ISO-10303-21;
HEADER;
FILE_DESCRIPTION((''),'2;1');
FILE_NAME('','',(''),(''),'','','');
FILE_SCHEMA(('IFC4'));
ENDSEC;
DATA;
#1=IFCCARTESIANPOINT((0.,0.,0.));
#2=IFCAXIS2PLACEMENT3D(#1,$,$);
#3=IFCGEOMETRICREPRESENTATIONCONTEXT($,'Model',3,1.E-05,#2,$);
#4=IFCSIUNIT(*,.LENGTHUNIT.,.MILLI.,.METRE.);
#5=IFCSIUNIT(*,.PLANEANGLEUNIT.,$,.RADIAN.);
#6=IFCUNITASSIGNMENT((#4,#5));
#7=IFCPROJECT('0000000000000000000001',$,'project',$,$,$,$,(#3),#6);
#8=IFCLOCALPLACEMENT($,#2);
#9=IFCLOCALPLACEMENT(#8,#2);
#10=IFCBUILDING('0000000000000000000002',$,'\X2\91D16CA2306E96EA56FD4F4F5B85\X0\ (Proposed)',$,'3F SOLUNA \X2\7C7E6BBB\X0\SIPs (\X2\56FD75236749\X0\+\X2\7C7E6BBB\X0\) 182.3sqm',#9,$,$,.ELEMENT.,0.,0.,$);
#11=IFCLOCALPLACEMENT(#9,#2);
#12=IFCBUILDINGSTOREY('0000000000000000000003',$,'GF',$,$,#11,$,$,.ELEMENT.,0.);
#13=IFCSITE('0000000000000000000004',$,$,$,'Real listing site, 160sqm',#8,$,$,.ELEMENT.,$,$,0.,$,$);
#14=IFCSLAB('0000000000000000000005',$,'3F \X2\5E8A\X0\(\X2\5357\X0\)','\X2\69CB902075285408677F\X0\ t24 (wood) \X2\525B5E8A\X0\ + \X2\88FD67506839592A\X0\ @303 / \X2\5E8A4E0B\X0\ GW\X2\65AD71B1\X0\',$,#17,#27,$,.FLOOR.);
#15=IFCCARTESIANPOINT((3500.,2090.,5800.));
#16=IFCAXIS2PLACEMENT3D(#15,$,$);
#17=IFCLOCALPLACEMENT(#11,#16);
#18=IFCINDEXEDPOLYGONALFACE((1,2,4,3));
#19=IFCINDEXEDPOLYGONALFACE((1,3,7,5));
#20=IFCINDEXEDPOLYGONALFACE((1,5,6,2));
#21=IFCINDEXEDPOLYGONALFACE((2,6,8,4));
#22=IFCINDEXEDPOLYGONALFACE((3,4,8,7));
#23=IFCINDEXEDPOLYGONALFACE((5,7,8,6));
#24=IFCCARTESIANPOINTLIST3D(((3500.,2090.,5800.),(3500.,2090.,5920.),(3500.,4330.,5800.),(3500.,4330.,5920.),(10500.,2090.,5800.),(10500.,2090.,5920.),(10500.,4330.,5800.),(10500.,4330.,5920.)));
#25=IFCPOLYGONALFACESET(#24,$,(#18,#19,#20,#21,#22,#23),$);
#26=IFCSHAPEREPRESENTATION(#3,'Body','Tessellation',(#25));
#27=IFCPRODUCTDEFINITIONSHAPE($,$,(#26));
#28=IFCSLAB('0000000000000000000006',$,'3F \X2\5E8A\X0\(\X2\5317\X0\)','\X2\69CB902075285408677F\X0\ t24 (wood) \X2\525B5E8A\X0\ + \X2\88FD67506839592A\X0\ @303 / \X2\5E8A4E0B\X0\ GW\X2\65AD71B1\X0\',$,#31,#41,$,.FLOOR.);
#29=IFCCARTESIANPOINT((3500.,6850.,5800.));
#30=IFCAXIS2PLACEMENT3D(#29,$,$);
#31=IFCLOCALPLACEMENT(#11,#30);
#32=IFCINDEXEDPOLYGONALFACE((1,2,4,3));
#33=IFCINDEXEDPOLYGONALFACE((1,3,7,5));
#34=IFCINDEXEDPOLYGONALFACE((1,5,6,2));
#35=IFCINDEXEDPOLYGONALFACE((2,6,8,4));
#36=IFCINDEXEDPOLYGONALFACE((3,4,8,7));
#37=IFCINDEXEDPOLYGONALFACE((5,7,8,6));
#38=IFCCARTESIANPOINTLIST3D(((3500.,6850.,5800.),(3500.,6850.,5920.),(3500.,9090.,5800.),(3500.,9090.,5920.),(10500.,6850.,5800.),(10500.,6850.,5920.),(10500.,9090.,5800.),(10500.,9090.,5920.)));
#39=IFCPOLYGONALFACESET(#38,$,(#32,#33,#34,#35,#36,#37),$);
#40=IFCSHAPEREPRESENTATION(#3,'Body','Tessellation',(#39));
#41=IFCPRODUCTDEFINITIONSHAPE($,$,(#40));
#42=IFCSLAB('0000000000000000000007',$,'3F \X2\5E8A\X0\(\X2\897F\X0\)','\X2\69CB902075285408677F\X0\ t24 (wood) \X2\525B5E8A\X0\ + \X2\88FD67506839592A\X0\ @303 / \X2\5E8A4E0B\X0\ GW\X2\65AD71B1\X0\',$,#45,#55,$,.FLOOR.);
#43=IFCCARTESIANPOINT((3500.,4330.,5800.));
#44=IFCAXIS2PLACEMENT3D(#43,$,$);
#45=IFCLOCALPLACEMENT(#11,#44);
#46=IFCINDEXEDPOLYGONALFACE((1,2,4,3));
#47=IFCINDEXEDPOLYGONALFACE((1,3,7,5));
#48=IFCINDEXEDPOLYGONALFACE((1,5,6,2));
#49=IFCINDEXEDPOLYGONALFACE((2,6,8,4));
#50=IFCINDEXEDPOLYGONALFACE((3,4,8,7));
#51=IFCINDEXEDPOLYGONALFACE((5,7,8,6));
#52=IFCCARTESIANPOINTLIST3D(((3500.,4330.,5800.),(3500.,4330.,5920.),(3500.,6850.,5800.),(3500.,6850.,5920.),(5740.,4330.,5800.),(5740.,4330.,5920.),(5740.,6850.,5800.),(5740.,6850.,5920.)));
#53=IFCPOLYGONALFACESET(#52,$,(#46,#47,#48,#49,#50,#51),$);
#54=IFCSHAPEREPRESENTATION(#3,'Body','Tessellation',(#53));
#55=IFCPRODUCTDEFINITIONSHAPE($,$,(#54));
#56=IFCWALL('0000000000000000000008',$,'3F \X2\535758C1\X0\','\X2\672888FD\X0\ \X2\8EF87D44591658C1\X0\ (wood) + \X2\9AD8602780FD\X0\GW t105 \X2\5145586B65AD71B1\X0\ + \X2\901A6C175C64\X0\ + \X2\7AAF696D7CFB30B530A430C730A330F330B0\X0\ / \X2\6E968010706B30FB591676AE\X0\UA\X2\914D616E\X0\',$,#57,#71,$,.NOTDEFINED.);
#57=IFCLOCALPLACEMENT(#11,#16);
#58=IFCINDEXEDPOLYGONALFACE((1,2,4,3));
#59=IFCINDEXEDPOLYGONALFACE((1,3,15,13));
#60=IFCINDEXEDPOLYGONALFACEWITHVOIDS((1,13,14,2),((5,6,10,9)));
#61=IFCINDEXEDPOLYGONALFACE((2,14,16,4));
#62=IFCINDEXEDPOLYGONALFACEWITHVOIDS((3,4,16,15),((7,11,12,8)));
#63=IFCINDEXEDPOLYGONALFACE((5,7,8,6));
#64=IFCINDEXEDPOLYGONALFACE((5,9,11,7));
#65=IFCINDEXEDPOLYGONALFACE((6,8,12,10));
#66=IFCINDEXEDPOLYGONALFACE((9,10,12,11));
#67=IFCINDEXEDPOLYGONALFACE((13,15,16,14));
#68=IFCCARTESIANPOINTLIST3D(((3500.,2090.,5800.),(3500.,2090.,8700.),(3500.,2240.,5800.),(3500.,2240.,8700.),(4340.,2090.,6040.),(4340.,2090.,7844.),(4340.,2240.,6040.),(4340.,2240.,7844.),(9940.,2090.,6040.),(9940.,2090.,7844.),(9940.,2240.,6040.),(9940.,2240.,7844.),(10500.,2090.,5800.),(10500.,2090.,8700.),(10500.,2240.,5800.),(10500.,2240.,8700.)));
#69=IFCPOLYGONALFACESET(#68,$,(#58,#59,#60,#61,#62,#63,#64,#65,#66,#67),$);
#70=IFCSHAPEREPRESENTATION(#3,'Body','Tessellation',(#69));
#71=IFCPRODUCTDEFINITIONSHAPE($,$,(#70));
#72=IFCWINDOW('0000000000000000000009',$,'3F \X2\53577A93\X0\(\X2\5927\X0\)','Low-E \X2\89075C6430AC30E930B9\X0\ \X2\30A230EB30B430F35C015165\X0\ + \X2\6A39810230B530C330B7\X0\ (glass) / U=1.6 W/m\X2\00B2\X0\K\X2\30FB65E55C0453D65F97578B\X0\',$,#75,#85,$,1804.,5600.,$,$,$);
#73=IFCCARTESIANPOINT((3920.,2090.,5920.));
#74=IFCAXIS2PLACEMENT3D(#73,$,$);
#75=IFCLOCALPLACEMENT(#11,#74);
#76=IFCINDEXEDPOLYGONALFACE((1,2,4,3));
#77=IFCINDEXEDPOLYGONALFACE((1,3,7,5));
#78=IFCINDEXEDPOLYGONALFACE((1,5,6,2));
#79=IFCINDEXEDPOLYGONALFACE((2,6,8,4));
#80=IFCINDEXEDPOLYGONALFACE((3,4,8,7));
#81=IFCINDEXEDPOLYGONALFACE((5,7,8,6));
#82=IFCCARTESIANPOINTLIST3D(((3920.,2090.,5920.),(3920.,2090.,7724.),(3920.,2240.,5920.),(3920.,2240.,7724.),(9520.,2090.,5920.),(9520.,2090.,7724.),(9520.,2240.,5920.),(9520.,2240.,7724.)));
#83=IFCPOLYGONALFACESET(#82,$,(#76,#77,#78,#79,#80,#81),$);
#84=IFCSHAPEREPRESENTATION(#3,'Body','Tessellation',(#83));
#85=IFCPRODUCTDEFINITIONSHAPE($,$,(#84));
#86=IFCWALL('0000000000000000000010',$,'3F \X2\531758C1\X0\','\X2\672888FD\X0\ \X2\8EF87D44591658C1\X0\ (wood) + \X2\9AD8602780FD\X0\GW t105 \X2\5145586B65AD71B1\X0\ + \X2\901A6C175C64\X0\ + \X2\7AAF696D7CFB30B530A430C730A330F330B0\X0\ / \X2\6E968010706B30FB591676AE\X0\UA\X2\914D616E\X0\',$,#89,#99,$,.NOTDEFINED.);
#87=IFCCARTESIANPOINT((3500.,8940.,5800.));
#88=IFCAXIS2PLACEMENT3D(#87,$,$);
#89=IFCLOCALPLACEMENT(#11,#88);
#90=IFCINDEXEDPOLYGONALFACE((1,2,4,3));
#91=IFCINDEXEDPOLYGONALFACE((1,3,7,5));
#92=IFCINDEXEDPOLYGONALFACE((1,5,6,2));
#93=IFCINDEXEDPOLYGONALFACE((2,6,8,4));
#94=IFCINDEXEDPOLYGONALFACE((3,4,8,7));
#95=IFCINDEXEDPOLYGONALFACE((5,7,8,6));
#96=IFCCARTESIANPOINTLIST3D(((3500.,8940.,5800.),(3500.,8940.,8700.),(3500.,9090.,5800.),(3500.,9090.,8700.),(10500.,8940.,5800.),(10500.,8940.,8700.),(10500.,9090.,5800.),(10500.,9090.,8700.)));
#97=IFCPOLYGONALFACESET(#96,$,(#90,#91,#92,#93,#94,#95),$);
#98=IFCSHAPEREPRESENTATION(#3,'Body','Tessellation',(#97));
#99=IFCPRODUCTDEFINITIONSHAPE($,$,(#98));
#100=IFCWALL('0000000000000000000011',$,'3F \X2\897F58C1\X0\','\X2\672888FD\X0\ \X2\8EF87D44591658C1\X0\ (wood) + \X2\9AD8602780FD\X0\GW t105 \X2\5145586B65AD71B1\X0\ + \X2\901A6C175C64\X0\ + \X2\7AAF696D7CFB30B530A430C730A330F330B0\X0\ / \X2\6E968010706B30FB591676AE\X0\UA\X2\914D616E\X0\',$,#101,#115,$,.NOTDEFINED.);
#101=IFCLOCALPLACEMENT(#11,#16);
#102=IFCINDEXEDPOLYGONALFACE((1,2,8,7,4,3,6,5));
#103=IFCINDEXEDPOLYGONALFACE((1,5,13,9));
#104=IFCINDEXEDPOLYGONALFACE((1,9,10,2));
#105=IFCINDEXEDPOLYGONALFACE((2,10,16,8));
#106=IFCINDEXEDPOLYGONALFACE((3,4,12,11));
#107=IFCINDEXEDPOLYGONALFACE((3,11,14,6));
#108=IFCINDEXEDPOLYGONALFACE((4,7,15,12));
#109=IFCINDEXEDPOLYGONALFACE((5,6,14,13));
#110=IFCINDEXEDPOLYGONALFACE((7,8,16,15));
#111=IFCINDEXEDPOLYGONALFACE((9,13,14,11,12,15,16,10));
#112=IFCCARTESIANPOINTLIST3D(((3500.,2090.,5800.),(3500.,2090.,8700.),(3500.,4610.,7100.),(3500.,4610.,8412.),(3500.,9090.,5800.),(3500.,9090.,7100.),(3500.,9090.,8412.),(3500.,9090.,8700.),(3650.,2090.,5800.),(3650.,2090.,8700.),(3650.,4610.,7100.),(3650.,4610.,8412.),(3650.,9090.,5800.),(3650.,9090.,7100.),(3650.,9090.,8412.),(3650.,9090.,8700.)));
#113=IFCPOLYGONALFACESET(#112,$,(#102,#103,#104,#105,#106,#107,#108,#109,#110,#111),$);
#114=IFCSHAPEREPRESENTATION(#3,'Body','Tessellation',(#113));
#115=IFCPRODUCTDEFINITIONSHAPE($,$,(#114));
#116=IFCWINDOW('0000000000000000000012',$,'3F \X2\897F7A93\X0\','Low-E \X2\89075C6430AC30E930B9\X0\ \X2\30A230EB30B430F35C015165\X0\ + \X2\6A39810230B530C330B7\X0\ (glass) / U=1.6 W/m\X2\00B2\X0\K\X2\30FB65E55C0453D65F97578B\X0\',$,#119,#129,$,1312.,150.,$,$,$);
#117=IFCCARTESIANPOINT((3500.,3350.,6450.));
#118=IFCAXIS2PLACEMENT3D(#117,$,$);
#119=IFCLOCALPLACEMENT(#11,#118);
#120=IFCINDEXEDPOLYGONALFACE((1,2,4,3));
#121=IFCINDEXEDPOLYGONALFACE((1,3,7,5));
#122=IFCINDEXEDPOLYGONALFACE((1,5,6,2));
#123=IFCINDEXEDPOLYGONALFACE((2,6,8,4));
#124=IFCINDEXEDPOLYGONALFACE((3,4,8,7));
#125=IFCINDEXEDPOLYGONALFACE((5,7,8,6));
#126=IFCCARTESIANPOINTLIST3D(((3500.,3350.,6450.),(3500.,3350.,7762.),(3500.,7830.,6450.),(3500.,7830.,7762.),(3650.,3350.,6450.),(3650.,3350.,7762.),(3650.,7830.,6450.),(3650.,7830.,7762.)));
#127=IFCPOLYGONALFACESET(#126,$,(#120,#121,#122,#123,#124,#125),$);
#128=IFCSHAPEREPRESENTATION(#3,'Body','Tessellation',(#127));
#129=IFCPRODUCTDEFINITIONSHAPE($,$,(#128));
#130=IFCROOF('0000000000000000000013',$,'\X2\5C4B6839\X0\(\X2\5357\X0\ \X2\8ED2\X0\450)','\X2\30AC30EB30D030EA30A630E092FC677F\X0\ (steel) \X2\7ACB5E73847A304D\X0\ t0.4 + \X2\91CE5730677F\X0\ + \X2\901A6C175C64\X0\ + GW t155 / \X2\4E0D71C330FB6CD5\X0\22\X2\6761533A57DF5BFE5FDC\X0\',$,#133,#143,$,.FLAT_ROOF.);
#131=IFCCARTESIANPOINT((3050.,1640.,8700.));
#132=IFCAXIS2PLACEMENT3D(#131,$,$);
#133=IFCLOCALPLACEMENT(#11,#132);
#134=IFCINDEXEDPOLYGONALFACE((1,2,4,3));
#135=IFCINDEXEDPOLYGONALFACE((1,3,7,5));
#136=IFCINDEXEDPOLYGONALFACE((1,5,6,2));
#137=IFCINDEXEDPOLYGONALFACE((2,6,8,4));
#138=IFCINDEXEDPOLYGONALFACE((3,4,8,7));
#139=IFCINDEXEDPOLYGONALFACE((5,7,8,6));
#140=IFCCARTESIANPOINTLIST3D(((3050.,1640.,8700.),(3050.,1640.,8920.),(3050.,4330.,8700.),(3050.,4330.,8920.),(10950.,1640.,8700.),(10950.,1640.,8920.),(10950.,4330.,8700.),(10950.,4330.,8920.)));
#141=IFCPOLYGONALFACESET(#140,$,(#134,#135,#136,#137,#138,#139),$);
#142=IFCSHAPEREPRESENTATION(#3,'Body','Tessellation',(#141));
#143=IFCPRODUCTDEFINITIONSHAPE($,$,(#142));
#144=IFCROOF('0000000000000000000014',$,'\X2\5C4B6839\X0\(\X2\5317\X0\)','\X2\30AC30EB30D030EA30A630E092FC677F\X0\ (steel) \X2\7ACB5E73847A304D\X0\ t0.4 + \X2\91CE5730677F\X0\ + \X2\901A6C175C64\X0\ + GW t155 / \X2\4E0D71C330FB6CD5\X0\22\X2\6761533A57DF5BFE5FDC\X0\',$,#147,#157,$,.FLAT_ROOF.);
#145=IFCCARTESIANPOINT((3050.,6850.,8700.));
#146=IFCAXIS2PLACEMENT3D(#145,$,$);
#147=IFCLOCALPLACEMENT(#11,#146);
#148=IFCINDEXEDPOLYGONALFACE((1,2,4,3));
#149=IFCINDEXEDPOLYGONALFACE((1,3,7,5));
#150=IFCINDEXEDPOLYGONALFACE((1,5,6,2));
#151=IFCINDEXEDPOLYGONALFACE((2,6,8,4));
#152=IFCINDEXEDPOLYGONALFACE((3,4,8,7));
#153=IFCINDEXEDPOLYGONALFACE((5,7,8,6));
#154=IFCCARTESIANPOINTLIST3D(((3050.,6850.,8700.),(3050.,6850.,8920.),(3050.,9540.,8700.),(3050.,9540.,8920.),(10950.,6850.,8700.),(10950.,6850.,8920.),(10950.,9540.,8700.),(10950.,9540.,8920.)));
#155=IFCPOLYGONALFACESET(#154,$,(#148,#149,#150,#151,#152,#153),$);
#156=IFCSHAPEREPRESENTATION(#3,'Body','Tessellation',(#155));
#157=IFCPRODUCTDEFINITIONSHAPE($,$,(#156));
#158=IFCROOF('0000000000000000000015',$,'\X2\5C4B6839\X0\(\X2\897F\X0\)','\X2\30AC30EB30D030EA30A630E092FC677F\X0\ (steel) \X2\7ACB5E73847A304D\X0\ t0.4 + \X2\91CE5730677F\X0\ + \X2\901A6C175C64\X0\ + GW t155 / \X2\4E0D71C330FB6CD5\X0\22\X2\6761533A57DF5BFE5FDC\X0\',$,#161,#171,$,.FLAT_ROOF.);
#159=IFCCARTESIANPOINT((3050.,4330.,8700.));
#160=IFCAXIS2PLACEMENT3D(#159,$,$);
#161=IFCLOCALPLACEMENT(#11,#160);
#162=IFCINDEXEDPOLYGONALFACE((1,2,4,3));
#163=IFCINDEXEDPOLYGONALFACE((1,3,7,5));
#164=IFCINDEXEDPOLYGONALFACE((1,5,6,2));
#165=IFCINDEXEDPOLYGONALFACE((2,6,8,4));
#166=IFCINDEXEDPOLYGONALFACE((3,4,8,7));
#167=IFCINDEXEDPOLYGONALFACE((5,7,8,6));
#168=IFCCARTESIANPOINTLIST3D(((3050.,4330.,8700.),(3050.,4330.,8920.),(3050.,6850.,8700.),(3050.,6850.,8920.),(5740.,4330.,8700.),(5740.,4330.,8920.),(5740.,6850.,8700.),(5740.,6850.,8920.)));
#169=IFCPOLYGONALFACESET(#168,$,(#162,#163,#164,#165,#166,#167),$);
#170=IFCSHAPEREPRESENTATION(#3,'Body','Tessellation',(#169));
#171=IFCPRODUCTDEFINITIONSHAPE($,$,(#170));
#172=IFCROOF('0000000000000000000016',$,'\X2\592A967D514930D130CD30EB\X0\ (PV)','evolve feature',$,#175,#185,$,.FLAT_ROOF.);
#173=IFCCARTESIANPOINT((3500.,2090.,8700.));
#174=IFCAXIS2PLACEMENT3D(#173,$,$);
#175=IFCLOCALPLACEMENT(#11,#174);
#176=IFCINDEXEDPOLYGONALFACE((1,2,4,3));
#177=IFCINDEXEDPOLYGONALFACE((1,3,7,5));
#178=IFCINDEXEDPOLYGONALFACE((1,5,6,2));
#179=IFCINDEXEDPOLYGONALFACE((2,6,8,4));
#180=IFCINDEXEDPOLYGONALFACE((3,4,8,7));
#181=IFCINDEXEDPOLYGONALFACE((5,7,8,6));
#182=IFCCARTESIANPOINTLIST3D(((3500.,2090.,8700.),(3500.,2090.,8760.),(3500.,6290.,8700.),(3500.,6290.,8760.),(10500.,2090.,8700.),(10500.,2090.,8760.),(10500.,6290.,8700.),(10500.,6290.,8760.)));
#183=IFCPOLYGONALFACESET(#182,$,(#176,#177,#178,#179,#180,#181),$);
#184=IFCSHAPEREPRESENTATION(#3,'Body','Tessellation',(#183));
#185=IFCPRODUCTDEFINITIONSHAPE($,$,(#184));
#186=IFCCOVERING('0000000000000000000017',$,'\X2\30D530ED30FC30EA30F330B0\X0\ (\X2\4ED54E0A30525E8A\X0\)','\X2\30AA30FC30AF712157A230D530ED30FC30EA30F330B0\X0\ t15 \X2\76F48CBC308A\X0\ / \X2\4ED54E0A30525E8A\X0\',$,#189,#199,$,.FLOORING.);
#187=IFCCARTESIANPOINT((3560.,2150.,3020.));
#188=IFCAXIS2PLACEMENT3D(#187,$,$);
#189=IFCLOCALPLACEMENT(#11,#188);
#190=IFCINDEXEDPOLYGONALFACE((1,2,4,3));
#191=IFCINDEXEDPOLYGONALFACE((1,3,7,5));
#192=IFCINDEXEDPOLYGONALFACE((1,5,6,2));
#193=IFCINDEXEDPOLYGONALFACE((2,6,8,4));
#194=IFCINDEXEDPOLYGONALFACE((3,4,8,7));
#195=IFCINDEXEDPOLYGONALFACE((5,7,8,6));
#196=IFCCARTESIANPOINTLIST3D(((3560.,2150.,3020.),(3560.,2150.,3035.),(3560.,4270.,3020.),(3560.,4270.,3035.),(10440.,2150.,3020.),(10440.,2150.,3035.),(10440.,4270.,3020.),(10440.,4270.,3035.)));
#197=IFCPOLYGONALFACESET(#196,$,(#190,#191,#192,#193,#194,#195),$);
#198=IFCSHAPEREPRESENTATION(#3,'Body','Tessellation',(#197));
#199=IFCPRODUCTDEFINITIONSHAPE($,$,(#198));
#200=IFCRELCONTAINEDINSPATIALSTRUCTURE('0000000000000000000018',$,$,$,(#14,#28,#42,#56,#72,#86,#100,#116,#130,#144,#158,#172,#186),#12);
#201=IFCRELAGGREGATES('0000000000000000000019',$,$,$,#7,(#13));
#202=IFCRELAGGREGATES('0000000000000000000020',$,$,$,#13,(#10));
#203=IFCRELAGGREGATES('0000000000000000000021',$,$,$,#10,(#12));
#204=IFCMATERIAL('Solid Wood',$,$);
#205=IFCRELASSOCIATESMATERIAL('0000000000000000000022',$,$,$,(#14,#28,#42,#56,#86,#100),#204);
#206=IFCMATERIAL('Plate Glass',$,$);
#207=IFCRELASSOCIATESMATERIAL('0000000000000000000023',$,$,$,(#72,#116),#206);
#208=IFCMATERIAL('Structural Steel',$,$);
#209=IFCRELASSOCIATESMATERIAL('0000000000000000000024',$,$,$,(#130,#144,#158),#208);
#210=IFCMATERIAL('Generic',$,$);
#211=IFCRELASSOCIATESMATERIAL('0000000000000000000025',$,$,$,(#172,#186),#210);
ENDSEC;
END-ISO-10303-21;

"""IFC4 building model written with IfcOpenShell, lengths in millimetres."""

from ifc_helpers import new_model, si_unit, frame, frame_2d, origin, place, context, project, spatial, rectangle, extrude, material, element, fill, save


model = new_model("IFC4")

# Units and contexts
model_context = context("Model", 3, precision=1e-05, world=origin())
ifc_project = project(units=[si_unit("LENGTHUNIT", "METRE", prefix="MILLI"), si_unit("PLANEANGLEUNIT", "RADIAN")], contexts=[model_context])

# Site, building, storey
site_placement = place(None, origin())
site = spatial("IfcSite", under=ifc_project, at=site_placement, ObjectType="Real listing site, 160sqm", CompositionType="ELEMENT", RefElevation=0.0)
building_placement = place(site_placement, origin())
building = spatial("IfcBuilding", under=site, at=building_placement, Name="金沢の雪国住宅 (Proposed)", ObjectType="3F SOLUNA 籾殻SIPs (国産杉+籾殻) 182.3sqm", CompositionType="ELEMENT", ElevationOfRefHeight=0.0, ElevationOfTerrain=0.0)
storey_placement = place(building_placement, origin())
storey = spatial("IfcBuildingStorey", under=building, at=storey_placement, Name="GF", CompositionType="ELEMENT", Elevation=0.0)

# Slabs
ifc_material_1 = material(Name="Solid Wood")
slab_1_placement = place(storey_placement, frame((3500.0, 2090.0, 5800.0)))
element("IfcSlab", 1, at=slab_1_placement, inside=storey, material=ifc_material_1, Name="3F 床(南)", Description="構造用合板 t24 (wood) 剛床 + 製材根太 @303 / 床下 GW断熱", PredefinedType="FLOOR", context=model_context, shape_type="SweptSolid", body=[
    extrude(rectangle(XDim=7000.0, YDim=2240.0, at=frame_2d((3500.0, 1120.0))), frame((3500.0, 2090.0, 5800.0)), (0.0, 0.0, 1.0), 120.0),
])
slab_2_placement = place(storey_placement, frame((3500.0, 6850.0, 5800.0)))
element("IfcSlab", 2, at=slab_2_placement, inside=storey, material=ifc_material_1, Name="3F 床(北)", Description="構造用合板 t24 (wood) 剛床 + 製材根太 @303 / 床下 GW断熱", PredefinedType="FLOOR", context=model_context, shape_type="SweptSolid", body=[
    extrude(rectangle(XDim=7000.0, YDim=2240.0, at=frame_2d((3500.0, 1120.0))), frame((3500.0, 6850.0, 5800.0)), (0.0, 0.0, 1.0), 120.0),
])
slab_3_placement = place(storey_placement, frame((3500.0, 4330.0, 5800.0)))
element("IfcSlab", 3, at=slab_3_placement, inside=storey, material=ifc_material_1, Name="3F 床(西)", Description="構造用合板 t24 (wood) 剛床 + 製材根太 @303 / 床下 GW断熱", PredefinedType="FLOOR", context=model_context, shape_type="SweptSolid", body=[
    extrude(rectangle(XDim=2240.0, YDim=2520.0, at=frame_2d((1120.0, 1260.0))), frame((3500.0, 4330.0, 5800.0)), (0.0, 0.0, 1.0), 120.0),
])

# Wall, opening, window
wall_1_placement = place(storey_placement, frame((3500.0, 2090.0, 5800.0)))
wall_1 = element("IfcWall", 4, at=wall_1_placement, inside=storey, material=ifc_material_1, Name="3F 南壁", Description="木製 軸組外壁 (wood) + 高性能GW t105 充填断熱 + 通気層 + 窯業系サイディング / 準耐火・外皮UA配慮", PredefinedType="NOTDEFINED", context=model_context, shape_type="SweptSolid", body=[
    extrude(rectangle(XDim=7000.0, YDim=150.0, at=frame_2d((3500.0, 75.0))), frame((3500.0, 2090.0, 5800.0)), (0.0, 0.0, 1.0), 2900.0),
])
opening_1_placement = place(storey_placement, frame((3920.0, 2090.0, 5920.0)))
opening_1 = element("IfcOpeningElement", 5, at=opening_1_placement, cuts=wall_1, PredefinedType="NOTDEFINED", context=model_context, shape_type="SweptSolid", body=[
    extrude(rectangle(XDim=5600.0, YDim=150.0, at=frame_2d((2800.0, 75.0))), frame((3920.0, 2090.0, 5920.0)), (0.0, 0.0, 1.0), 1804.0),
])
ifc_material_2 = material(Name="Plate Glass")
window_1_placement = place(storey_placement, frame((3920.0, 2090.0, 5920.0)))
window_1 = element("IfcWindow", 6, at=window_1_placement, inside=storey, material=ifc_material_2, Name="3F 南窓(大)", Description="Low-E 複層ガラス アルゴン封入 + 樹脂サッシ (glass) / U=1.6 W/m²K・日射取得型", OverallHeight=1804.0, OverallWidth=5600.0, context=model_context, shape_type="SweptSolid", body=[
    extrude(rectangle(XDim=5600.0, YDim=150.0, at=frame_2d((2800.0, 75.0))), frame((3920.0, 2090.0, 5920.0)), (0.0, 0.0, 1.0), 1804.0),
])
fill(opening_1, window_1)

# Wall
wall_2_placement = place(storey_placement, frame((3500.0, 8940.0, 5800.0)))
element("IfcWall", 7, at=wall_2_placement, inside=storey, material=ifc_material_1, Name="3F 北壁", Description="木製 軸組外壁 (wood) + 高性能GW t105 充填断熱 + 通気層 + 窯業系サイディング / 準耐火・外皮UA配慮", PredefinedType="NOTDEFINED", context=model_context, shape_type="SweptSolid", body=[
    extrude(rectangle(XDim=7000.0, YDim=150.0, at=frame_2d((3500.0, 75.0))), frame((3500.0, 8940.0, 5800.0)), (0.0, 0.0, 1.0), 2900.0),
])

# Wall, opening, window
wall_3_placement = place(storey_placement, frame((3500.0, 2090.0, 5800.0)))
wall_3 = element("IfcWall", 8, at=wall_3_placement, inside=storey, material=ifc_material_1, Name="3F 西壁", Description="木製 軸組外壁 (wood) + 高性能GW t105 充填断熱 + 通気層 + 窯業系サイディング / 準耐火・外皮UA配慮", PredefinedType="NOTDEFINED", context=model_context, shape_type="SweptSolid", body=[
    extrude(rectangle(XDim=150.0, YDim=7000.0, at=frame_2d((75.0, 3500.0))), frame((3500.0, 2090.0, 5800.0)), (0.0, 0.0, 1.0), 2900.0),
])
opening_2_placement = place(storey_placement, frame((3500.0, 3350.0, 6450.0)))
opening_2 = element("IfcOpeningElement", 9, at=opening_2_placement, cuts=wall_3, PredefinedType="NOTDEFINED", context=model_context, shape_type="SweptSolid", body=[
    extrude(rectangle(XDim=150.0, YDim=4480.0, at=frame_2d((75.0, 2240.0))), frame((3500.0, 3350.0, 6450.0)), (0.0, 0.0, 1.0), 1312.0),
])
window_2_placement = place(storey_placement, frame((3500.0, 3350.0, 6450.0)))
window_2 = element("IfcWindow", 10, at=window_2_placement, inside=storey, material=ifc_material_2, Name="3F 西窓", Description="Low-E 複層ガラス アルゴン封入 + 樹脂サッシ (glass) / U=1.6 W/m²K・日射取得型", OverallHeight=1312.0, OverallWidth=150.0, context=model_context, shape_type="SweptSolid", body=[
    extrude(rectangle(XDim=150.0, YDim=4480.0, at=frame_2d((75.0, 2240.0))), frame((3500.0, 3350.0, 6450.0)), (0.0, 0.0, 1.0), 1312.0),
])
fill(opening_2, window_2)

# Roofs
ifc_material_3 = material(Name="Structural Steel")
roof_1_placement = place(storey_placement, frame((3050.0, 1640.0, 8700.0)))
element("IfcRoof", 11, at=roof_1_placement, inside=storey, material=ifc_material_3, Name="屋根(南 軒450)", Description="ガルバリウム鋼板 (steel) 立平葺き t0.4 + 野地板 + 通気層 + GW t155 / 不燃・法22条区域対応", PredefinedType="FLAT_ROOF", context=model_context, shape_type="SweptSolid", body=[
    extrude(rectangle(XDim=7900.0, YDim=2690.0, at=frame_2d((3950.0, 1345.0))), frame((3050.0, 1640.0, 8700.0)), (0.0, 0.0, 1.0), 220.0),
])
roof_2_placement = place(storey_placement, frame((3050.0, 6850.0, 8700.0)))
element("IfcRoof", 12, at=roof_2_placement, inside=storey, material=ifc_material_3, Name="屋根(北)", Description="ガルバリウム鋼板 (steel) 立平葺き t0.4 + 野地板 + 通気層 + GW t155 / 不燃・法22条区域対応", PredefinedType="FLAT_ROOF", context=model_context, shape_type="SweptSolid", body=[
    extrude(rectangle(XDim=7900.0, YDim=2690.0, at=frame_2d((3950.0, 1345.0))), frame((3050.0, 6850.0, 8700.0)), (0.0, 0.0, 1.0), 220.0),
])
roof_3_placement = place(storey_placement, frame((3050.0, 4330.0, 8700.0)))
element("IfcRoof", 13, at=roof_3_placement, inside=storey, material=ifc_material_3, Name="屋根(西)", Description="ガルバリウム鋼板 (steel) 立平葺き t0.4 + 野地板 + 通気層 + GW t155 / 不燃・法22条区域対応", PredefinedType="FLAT_ROOF", context=model_context, shape_type="SweptSolid", body=[
    extrude(rectangle(XDim=2690.0, YDim=2520.0, at=frame_2d((1345.0, 1260.0))), frame((3050.0, 4330.0, 8700.0)), (0.0, 0.0, 1.0), 220.0),
])
ifc_material_4 = material(Name="Generic")
roof_4_placement = place(storey_placement, frame((3500.0, 2090.0, 8700.0)))
element("IfcRoof", 14, at=roof_4_placement, inside=storey, material=ifc_material_4, Name="太陽光パネル (PV)", Description="evolve feature", PredefinedType="FLAT_ROOF", context=model_context, shape_type="SweptSolid", body=[
    extrude(rectangle(XDim=7000.0, YDim=4200.0, at=frame_2d((3500.0, 2100.0))), frame((3500.0, 2090.0, 8700.0)), (0.0, 0.0, 1.0), 60.0),
])

# Covering
covering_1_placement = place(storey_placement, frame((3560.0, 2150.0, 3020.0)))
element("IfcCovering", 15, at=covering_1_placement, inside=storey, material=ifc_material_4, Name="フローリング (仕上げ床)", Description="オーク無垢フローリング t15 直貼り / 仕上げ床", PredefinedType="FLOORING", context=model_context, shape_type="SweptSolid", body=[
    extrude(rectangle(XDim=6880.0, YDim=2120.0, at=frame_2d((3440.0, 1060.0))), frame((3560.0, 2150.0, 3020.0)), (0.0, 0.0, 1.0), 15.0),
])

save(model, "model.ifc")
